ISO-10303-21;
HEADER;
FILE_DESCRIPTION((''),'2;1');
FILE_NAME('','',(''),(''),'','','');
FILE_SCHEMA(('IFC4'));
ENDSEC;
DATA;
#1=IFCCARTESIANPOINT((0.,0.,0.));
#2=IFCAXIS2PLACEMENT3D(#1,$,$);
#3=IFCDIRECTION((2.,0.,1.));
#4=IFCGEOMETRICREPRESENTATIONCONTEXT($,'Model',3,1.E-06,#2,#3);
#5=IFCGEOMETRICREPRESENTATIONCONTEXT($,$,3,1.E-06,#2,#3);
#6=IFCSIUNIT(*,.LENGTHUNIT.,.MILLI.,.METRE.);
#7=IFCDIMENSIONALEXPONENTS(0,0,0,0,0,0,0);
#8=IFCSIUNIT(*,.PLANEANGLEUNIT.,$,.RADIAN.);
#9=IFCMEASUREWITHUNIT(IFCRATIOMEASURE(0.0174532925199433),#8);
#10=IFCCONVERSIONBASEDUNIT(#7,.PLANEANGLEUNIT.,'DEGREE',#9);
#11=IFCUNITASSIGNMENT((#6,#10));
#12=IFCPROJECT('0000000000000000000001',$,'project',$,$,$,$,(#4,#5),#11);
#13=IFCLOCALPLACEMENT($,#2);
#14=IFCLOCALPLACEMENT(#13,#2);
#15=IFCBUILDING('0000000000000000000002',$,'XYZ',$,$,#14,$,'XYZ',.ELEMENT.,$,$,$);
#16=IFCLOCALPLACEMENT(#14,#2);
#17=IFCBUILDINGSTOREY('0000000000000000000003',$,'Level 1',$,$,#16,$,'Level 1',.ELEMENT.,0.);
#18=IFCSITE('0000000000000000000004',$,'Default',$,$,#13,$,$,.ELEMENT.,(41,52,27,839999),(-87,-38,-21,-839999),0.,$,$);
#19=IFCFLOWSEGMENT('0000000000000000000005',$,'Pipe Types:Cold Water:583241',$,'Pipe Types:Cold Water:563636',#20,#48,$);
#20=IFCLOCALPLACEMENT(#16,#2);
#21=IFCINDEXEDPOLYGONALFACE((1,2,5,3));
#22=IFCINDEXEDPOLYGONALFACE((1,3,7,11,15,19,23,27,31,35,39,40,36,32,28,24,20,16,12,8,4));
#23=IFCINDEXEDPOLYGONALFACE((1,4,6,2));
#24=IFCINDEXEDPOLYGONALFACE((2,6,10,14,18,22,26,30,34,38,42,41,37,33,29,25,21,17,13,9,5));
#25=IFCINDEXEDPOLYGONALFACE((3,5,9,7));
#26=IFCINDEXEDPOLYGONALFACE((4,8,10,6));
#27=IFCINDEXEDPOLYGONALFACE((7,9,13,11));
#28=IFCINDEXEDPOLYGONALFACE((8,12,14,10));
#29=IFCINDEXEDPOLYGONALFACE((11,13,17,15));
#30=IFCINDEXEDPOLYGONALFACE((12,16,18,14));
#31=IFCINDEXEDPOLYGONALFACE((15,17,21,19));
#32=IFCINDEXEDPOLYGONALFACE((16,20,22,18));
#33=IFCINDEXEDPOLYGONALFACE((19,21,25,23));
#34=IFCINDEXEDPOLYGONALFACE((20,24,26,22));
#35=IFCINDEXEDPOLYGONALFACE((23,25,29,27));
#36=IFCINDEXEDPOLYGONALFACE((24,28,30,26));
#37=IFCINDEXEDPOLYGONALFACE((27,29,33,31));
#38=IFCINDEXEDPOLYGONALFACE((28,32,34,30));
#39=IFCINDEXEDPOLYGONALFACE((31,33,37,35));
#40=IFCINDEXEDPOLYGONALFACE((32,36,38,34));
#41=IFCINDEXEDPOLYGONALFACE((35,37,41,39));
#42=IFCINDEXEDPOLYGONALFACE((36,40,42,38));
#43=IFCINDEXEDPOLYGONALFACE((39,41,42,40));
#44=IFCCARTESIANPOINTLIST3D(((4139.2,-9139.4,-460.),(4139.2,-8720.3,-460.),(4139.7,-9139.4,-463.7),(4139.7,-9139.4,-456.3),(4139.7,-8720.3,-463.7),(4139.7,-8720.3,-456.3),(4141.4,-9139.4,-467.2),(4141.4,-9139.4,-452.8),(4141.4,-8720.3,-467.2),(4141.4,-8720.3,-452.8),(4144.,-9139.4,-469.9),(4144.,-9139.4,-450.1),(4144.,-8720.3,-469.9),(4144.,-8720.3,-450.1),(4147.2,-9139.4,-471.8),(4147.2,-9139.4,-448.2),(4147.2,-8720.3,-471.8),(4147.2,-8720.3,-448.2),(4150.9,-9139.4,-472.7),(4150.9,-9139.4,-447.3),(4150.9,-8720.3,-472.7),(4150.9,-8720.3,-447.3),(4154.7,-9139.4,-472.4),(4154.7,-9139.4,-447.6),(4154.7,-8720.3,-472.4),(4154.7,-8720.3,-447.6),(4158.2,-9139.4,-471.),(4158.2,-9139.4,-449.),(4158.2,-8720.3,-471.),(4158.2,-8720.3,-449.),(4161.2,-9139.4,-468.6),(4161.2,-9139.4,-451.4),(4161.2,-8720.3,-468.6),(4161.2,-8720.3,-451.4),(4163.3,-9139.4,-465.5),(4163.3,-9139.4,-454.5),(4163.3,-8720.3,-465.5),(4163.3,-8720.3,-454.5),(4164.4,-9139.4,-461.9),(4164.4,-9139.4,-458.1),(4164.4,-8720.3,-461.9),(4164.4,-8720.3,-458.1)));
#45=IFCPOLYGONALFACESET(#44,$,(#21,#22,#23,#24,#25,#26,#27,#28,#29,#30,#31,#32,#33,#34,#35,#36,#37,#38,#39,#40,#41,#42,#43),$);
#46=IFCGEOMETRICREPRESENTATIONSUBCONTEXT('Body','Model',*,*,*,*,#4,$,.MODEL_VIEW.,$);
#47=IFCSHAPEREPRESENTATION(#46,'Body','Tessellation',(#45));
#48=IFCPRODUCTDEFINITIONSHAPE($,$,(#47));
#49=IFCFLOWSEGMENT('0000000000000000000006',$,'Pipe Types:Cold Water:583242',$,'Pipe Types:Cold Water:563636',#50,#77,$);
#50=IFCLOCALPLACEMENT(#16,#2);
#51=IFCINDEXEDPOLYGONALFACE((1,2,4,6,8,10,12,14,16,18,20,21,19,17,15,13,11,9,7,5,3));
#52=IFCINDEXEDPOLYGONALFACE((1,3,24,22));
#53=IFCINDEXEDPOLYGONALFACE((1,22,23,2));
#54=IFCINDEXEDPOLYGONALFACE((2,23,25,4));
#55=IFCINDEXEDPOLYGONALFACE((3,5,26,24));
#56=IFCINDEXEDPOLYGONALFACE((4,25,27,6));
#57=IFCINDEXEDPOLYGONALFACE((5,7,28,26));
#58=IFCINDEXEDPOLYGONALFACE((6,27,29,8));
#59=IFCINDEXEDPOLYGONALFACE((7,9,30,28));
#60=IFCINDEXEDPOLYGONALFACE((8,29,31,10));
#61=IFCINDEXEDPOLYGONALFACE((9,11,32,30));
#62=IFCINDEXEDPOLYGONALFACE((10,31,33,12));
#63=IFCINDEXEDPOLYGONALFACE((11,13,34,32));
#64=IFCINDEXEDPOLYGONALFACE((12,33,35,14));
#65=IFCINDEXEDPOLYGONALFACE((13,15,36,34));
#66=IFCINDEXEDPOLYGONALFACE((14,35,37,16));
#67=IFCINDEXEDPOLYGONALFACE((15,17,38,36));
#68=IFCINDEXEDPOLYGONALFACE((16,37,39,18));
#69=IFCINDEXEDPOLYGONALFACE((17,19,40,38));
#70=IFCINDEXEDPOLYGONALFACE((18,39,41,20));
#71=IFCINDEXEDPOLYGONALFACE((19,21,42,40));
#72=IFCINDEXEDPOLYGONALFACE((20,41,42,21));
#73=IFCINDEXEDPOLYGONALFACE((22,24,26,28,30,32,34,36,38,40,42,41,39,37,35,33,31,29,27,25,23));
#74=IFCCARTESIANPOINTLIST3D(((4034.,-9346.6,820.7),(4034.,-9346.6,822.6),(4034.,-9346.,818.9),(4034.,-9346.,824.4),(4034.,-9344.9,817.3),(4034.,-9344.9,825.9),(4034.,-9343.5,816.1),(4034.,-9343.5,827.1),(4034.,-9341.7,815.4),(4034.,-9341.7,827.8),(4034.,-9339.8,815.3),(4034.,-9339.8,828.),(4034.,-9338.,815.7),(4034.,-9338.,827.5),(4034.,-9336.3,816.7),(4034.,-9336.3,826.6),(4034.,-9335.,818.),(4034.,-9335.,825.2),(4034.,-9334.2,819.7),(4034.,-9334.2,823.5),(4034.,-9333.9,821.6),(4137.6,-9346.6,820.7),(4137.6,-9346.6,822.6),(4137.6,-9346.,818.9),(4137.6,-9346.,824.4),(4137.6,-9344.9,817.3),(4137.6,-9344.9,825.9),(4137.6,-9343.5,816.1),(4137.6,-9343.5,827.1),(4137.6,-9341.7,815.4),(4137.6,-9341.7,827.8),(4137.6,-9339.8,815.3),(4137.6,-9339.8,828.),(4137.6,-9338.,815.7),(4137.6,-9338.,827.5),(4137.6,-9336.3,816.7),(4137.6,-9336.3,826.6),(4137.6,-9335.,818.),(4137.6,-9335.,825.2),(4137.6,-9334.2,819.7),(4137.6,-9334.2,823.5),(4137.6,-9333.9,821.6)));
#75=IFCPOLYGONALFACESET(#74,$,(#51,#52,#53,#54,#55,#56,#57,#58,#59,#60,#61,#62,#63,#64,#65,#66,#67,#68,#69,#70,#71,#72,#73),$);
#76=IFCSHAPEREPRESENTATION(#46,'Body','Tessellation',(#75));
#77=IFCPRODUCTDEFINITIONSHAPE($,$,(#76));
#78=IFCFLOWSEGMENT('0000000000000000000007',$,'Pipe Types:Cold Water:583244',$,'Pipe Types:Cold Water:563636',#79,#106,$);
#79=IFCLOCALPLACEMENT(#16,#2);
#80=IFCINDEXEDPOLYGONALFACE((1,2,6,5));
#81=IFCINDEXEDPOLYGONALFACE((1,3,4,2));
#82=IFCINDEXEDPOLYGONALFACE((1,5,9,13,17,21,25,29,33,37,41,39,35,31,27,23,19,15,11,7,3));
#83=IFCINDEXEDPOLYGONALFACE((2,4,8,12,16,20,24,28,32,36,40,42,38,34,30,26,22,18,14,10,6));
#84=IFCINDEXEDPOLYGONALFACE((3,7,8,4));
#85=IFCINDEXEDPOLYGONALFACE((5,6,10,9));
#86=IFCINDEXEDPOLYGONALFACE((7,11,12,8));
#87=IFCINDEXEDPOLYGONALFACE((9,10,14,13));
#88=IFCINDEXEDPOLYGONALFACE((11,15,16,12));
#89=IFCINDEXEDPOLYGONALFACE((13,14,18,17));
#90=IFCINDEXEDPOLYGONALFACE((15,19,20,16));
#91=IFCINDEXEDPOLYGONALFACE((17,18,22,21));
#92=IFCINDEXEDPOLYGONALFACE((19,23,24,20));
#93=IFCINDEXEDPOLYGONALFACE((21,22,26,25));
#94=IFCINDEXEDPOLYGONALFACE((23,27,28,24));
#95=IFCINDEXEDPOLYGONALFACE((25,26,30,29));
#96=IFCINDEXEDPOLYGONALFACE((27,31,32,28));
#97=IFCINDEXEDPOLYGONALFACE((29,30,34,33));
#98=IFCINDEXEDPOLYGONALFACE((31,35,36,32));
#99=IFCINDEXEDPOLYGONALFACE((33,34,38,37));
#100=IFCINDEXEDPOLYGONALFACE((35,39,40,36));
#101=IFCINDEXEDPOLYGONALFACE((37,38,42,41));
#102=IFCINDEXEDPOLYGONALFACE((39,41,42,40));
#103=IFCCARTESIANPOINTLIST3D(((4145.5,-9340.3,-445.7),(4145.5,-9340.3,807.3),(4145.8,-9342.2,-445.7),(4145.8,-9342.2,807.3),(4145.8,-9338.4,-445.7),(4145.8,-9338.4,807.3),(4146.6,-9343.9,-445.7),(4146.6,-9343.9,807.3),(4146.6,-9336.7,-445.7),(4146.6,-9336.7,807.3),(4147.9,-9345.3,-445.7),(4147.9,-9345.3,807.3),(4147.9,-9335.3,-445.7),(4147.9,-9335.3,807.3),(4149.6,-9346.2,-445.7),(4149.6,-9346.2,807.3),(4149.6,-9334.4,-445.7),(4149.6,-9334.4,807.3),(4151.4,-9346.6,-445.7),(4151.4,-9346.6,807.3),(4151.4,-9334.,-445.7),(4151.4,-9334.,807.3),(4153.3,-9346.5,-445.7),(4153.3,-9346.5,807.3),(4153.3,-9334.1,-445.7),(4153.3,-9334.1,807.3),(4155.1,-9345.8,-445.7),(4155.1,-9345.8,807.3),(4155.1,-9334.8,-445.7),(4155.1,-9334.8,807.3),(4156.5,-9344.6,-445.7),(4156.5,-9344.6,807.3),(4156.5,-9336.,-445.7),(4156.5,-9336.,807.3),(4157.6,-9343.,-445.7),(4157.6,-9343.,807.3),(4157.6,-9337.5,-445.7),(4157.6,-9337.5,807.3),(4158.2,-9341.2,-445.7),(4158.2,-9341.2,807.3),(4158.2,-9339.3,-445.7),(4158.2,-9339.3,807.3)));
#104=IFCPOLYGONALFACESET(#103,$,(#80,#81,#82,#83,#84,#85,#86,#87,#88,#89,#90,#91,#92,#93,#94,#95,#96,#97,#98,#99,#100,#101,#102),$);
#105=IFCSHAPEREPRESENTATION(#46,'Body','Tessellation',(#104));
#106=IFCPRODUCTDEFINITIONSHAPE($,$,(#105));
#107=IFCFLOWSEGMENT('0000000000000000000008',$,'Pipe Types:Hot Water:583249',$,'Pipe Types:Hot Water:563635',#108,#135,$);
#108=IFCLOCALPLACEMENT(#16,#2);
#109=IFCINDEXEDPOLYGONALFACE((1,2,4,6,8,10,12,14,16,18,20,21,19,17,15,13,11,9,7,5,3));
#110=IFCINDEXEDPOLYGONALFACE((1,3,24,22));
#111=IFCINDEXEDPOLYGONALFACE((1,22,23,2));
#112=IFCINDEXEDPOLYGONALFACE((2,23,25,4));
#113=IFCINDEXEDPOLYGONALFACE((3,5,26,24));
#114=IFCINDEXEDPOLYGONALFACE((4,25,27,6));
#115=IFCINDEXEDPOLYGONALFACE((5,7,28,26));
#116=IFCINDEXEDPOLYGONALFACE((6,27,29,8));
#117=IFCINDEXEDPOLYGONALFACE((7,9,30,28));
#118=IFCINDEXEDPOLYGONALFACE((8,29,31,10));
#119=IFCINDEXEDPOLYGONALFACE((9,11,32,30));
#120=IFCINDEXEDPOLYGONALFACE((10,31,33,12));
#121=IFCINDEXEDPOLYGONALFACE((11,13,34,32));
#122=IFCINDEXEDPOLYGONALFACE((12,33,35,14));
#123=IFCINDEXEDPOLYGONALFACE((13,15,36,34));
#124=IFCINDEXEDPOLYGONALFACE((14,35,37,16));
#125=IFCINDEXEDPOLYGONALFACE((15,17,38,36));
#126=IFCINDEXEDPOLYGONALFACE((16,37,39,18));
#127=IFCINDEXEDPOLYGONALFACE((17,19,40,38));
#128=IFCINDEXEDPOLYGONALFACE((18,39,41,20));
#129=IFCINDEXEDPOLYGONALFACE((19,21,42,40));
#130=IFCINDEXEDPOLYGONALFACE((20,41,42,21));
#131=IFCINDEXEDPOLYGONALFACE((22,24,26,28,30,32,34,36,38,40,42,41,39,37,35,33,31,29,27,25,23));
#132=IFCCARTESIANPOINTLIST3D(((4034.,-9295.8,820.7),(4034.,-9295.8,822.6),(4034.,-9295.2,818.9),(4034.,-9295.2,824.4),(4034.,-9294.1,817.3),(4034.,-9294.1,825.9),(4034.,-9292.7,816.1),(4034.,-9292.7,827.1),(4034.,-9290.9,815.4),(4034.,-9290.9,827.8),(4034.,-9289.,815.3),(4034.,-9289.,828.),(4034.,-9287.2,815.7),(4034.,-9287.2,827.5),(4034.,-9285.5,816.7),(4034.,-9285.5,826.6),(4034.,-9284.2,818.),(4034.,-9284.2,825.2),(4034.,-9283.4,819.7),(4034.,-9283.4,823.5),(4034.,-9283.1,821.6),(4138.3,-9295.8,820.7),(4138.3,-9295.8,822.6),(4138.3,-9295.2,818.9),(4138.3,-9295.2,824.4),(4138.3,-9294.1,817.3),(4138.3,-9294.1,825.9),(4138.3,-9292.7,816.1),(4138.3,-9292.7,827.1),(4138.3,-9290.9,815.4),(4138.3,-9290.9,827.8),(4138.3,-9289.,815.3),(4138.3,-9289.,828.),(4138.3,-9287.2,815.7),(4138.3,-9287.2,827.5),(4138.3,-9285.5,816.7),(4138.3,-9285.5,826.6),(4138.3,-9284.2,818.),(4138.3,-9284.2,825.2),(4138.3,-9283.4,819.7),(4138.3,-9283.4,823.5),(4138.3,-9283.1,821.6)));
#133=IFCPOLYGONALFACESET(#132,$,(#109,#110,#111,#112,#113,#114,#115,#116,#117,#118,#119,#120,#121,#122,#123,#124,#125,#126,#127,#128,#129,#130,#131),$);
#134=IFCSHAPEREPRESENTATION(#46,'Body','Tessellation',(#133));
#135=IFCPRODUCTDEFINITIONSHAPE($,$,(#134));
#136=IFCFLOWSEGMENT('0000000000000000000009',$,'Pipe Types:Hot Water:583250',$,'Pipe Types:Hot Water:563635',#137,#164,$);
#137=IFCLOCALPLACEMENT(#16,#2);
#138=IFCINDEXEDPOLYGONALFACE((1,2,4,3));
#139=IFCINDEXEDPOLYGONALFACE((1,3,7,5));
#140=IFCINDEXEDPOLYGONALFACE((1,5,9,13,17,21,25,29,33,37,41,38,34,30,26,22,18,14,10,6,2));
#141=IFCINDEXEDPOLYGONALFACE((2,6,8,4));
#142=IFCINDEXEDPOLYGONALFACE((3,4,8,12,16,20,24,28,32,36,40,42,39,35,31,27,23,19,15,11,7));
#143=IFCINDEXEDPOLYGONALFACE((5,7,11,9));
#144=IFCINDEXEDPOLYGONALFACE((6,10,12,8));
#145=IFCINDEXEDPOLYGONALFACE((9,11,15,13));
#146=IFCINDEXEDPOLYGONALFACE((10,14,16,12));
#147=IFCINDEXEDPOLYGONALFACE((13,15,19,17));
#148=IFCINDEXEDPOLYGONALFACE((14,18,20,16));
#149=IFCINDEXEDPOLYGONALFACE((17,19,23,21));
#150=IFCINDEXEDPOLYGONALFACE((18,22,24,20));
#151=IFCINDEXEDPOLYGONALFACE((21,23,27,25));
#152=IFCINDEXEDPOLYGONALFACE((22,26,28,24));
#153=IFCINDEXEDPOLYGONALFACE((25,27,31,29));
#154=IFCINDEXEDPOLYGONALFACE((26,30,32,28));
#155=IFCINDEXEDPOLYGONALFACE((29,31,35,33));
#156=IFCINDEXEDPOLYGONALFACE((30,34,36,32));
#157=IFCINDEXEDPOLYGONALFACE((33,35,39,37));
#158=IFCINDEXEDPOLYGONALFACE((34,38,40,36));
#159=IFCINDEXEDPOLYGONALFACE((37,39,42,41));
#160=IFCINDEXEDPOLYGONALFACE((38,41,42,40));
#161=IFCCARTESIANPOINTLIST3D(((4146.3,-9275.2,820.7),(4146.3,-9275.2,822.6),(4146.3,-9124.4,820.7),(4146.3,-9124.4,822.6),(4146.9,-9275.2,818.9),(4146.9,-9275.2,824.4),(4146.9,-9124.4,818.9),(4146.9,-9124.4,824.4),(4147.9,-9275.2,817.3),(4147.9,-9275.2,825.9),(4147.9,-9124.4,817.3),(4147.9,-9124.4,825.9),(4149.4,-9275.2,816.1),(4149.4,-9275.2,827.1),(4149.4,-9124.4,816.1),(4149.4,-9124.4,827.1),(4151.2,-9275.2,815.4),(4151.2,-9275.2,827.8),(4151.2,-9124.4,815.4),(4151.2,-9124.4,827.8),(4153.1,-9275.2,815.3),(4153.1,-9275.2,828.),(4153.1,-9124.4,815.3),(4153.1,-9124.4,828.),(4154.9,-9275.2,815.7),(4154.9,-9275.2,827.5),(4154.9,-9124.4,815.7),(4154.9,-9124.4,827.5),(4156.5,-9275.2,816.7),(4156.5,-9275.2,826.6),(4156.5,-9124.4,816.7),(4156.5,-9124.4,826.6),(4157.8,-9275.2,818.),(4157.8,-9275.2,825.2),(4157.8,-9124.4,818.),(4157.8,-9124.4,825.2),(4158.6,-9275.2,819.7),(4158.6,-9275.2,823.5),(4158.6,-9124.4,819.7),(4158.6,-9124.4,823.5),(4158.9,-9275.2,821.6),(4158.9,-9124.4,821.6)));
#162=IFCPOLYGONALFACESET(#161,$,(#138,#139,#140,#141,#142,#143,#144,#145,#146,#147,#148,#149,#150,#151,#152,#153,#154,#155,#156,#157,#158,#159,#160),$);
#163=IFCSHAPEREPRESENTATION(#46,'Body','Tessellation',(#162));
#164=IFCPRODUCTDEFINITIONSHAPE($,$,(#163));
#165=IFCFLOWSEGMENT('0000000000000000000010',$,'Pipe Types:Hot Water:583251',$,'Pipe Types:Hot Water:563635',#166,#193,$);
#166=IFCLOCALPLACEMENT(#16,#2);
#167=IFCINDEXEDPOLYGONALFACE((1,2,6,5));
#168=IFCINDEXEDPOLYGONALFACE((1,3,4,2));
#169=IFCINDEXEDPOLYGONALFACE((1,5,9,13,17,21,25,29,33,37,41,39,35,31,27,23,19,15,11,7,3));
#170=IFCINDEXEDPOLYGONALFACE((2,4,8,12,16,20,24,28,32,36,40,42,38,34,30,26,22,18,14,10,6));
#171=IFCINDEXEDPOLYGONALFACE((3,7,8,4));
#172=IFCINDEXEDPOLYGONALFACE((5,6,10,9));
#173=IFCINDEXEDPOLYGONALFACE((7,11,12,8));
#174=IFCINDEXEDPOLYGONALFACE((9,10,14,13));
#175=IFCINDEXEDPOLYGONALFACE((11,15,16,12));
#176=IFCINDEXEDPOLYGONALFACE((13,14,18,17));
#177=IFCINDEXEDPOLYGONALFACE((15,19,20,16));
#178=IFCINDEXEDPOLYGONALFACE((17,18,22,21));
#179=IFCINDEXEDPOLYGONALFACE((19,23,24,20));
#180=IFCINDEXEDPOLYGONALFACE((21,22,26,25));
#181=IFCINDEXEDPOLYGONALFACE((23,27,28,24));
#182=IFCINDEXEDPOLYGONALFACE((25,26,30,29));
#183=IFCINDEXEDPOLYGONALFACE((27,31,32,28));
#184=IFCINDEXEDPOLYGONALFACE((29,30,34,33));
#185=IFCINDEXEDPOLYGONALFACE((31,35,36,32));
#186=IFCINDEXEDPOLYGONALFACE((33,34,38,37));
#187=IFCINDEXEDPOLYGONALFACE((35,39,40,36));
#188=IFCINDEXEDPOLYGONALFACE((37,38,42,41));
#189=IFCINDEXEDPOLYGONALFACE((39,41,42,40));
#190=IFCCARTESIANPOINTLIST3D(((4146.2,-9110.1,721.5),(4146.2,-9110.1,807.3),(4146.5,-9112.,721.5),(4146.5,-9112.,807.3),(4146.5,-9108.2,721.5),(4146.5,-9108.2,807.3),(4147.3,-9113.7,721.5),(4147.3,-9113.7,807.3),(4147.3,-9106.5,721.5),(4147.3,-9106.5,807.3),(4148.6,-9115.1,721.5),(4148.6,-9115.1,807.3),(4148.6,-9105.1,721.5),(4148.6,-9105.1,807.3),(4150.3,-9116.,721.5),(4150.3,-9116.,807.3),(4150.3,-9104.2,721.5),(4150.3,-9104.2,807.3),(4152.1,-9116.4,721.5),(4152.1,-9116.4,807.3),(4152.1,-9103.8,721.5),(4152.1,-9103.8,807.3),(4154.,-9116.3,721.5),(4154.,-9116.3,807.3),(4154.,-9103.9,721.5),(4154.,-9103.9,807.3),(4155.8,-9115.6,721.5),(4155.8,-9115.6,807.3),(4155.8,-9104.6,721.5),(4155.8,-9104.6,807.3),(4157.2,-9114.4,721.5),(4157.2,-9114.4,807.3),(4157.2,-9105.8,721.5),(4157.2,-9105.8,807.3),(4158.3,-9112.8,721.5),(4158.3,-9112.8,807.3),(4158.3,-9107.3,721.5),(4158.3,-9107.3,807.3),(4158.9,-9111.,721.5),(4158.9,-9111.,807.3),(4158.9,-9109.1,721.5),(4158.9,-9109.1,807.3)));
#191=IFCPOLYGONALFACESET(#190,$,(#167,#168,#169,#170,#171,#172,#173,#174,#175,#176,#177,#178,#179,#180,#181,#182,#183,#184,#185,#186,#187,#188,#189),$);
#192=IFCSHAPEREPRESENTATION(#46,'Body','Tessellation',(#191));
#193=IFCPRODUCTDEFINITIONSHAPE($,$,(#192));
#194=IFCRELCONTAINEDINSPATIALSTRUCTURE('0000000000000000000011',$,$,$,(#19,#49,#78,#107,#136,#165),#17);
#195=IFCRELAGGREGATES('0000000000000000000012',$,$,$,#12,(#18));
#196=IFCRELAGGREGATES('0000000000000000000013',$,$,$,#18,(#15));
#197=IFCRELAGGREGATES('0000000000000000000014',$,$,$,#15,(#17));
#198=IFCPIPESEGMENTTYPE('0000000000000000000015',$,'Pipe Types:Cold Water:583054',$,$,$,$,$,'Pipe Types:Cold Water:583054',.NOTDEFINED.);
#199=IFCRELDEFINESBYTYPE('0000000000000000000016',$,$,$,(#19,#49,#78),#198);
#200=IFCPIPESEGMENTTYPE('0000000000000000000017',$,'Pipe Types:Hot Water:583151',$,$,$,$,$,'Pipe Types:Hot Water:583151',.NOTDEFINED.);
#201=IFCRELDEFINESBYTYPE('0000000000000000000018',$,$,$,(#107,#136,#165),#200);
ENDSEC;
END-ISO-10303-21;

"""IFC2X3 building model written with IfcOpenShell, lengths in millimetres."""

from ifc_helpers import new_model, entity, si_unit, converted_unit, direction, frame, frame_2d, origin, origin_2d_with_axis, place, context, subcontext, project, spatial, circle, extrude, type_object, element, save


model = new_model("IFC2X3")

# Units and contexts
model_context = context("Model", 3, precision=1e-06, world=origin(), true_north=direction((2.0, 0.0, 1.0)))
context_of_model = context(None, 3, precision=1e-06, world=origin(), true_north=direction((2.0, 0.0, 1.0)))
body_context = subcontext(model_context, "Body", "Model", "MODEL_VIEW")
ifc_project = project(units=[si_unit("LENGTHUNIT", "METRE", prefix="MILLI"), converted_unit("PLANEANGLEUNIT", "DEGREE", entity("IfcRatioMeasure", 0.0174532925199433), si_unit("PLANEANGLEUNIT", "RADIAN"), dimensions=[0, 0, 0, 0, 0, 0, 0])], contexts=[model_context, context_of_model])

# Site, building, storey
site_placement = place(None, origin())
site = spatial("IfcSite", under=ifc_project, at=site_placement, Name="Default", CompositionType="ELEMENT", RefLatitude=(41, 52, 27, 839999), RefLongitude=(-87, -38, -21, -839999), RefElevation=0.0)
building_placement = place(site_placement, origin())
building = spatial("IfcBuilding", under=site, at=building_placement, Name="XYZ", LongName="XYZ", CompositionType="ELEMENT")
storey_placement = place(building_placement, origin())
storey = spatial("IfcBuildingStorey", under=building, at=storey_placement, Name="Level 1", LongName="Level 1", CompositionType="ELEMENT", Elevation=0.0)

# Flow segments
pipe_segment_type_1 = type_object("IfcPipeSegmentType", Name="Pipe Types:Cold Water:583054", ElementType="Pipe Types:Cold Water:583054", PredefinedType="NOTDEFINED")
flow_segment_1_placement = place(storey_placement, origin())
element("IfcFlowSegment", 1, at=flow_segment_1_placement, inside=storey, type_object=pipe_segment_type_1, Name="Pipe Types:Cold Water:583241", ObjectType="Pipe Types:Cold Water:563636", context=body_context, shape_type="SweptSolid", body=[
    extrude(circle(Radius=12.7, at=frame_2d((0.0, 0.0), x_axis=(1.0, 0.0))), frame((4151.9, -9139.4, -460.0), z_axis=(0.0, 1.0, 0.0), x_axis=(-1.0, 0.0, 0.0)), (0.0, 0.0, 1.0), 419.1),
])
flow_segment_2_placement = place(storey_placement, origin())
element("IfcFlowSegment", 2, at=flow_segment_2_placement, inside=storey, type_object=pipe_segment_type_1, Name="Pipe Types:Cold Water:583242", ObjectType="Pipe Types:Cold Water:563636", context=body_context, shape_type="SweptSolid", body=[
    extrude(circle(Radius=6.3, at=frame_2d((0.0, 0.0), x_axis=(1.0, 0.0))), frame((4034.0, -9340.3, 821.6), z_axis=(1.0, 0.0, 0.0), x_axis=(0.0, 1.0, 0.0)), (0.0, 0.0, 1.0), 103.6),
])
flow_segment_3_placement = place(storey_placement, origin())
element("IfcFlowSegment", 3, at=flow_segment_3_placement, inside=storey, type_object=pipe_segment_type_1, Name="Pipe Types:Cold Water:583244", ObjectType="Pipe Types:Cold Water:563636", context=body_context, shape_type="SweptSolid", body=[
    extrude(circle(Radius=6.3, at=frame_2d((0.0, 0.0), x_axis=(1.0, 0.0))), frame((4151.9, -9340.3, -445.7), z_axis=(0.0, 0.0, 1.0), x_axis=(-1.0, 0.0, 0.0)), (0.0, 0.0, 1.0), 1253.0),
])
pipe_segment_type_2 = type_object("IfcPipeSegmentType", Name="Pipe Types:Hot Water:583151", ElementType="Pipe Types:Hot Water:583151", PredefinedType="NOTDEFINED")
flow_segment_4_placement = place(storey_placement, origin())
element("IfcFlowSegment", 4, at=flow_segment_4_placement, inside=storey, type_object=pipe_segment_type_2, Name="Pipe Types:Hot Water:583249", ObjectType="Pipe Types:Hot Water:563635", context=body_context, shape_type="SweptSolid", body=[
    extrude(circle(Radius=6.3, at=frame_2d((0.0, 0.0), x_axis=(1.0, 0.0))), frame((4034.0, -9289.5, 821.6), z_axis=(1.0, 0.0, 0.0), x_axis=(0.0, 1.0, 0.0)), (0.0, 0.0, 1.0), 104.3),
])
flow_segment_5_placement = place(storey_placement, origin())
element("IfcFlowSegment", 5, at=flow_segment_5_placement, inside=storey, type_object=pipe_segment_type_2, Name="Pipe Types:Hot Water:583250", ObjectType="Pipe Types:Hot Water:563635", context=body_context, shape_type="SweptSolid", body=[
    extrude(circle(Radius=6.3, at=origin_2d_with_axis()), frame((4152.6, -9275.2, 821.6), z_axis=(0.0, 1.0, 0.0), x_axis=(1.0, 0.0, 0.0)), (0.0, 0.0, 1.0), 150.8),
])
flow_segment_6_placement = place(storey_placement, origin())
element("IfcFlowSegment", 6, at=flow_segment_6_placement, inside=storey, type_object=pipe_segment_type_2, Name="Pipe Types:Hot Water:583251", ObjectType="Pipe Types:Hot Water:563635", context=body_context, shape_type="SweptSolid", body=[
    extrude(circle(Radius=6.3, at=origin_2d_with_axis()), frame((4152.6, -9110.1, 721.5), z_axis=(0.0, 0.0, 1.0), x_axis=(-1.0, 0.0, 0.0)), (0.0, 0.0, 1.0), 85.8),
])

save(model, "model.ifc")
